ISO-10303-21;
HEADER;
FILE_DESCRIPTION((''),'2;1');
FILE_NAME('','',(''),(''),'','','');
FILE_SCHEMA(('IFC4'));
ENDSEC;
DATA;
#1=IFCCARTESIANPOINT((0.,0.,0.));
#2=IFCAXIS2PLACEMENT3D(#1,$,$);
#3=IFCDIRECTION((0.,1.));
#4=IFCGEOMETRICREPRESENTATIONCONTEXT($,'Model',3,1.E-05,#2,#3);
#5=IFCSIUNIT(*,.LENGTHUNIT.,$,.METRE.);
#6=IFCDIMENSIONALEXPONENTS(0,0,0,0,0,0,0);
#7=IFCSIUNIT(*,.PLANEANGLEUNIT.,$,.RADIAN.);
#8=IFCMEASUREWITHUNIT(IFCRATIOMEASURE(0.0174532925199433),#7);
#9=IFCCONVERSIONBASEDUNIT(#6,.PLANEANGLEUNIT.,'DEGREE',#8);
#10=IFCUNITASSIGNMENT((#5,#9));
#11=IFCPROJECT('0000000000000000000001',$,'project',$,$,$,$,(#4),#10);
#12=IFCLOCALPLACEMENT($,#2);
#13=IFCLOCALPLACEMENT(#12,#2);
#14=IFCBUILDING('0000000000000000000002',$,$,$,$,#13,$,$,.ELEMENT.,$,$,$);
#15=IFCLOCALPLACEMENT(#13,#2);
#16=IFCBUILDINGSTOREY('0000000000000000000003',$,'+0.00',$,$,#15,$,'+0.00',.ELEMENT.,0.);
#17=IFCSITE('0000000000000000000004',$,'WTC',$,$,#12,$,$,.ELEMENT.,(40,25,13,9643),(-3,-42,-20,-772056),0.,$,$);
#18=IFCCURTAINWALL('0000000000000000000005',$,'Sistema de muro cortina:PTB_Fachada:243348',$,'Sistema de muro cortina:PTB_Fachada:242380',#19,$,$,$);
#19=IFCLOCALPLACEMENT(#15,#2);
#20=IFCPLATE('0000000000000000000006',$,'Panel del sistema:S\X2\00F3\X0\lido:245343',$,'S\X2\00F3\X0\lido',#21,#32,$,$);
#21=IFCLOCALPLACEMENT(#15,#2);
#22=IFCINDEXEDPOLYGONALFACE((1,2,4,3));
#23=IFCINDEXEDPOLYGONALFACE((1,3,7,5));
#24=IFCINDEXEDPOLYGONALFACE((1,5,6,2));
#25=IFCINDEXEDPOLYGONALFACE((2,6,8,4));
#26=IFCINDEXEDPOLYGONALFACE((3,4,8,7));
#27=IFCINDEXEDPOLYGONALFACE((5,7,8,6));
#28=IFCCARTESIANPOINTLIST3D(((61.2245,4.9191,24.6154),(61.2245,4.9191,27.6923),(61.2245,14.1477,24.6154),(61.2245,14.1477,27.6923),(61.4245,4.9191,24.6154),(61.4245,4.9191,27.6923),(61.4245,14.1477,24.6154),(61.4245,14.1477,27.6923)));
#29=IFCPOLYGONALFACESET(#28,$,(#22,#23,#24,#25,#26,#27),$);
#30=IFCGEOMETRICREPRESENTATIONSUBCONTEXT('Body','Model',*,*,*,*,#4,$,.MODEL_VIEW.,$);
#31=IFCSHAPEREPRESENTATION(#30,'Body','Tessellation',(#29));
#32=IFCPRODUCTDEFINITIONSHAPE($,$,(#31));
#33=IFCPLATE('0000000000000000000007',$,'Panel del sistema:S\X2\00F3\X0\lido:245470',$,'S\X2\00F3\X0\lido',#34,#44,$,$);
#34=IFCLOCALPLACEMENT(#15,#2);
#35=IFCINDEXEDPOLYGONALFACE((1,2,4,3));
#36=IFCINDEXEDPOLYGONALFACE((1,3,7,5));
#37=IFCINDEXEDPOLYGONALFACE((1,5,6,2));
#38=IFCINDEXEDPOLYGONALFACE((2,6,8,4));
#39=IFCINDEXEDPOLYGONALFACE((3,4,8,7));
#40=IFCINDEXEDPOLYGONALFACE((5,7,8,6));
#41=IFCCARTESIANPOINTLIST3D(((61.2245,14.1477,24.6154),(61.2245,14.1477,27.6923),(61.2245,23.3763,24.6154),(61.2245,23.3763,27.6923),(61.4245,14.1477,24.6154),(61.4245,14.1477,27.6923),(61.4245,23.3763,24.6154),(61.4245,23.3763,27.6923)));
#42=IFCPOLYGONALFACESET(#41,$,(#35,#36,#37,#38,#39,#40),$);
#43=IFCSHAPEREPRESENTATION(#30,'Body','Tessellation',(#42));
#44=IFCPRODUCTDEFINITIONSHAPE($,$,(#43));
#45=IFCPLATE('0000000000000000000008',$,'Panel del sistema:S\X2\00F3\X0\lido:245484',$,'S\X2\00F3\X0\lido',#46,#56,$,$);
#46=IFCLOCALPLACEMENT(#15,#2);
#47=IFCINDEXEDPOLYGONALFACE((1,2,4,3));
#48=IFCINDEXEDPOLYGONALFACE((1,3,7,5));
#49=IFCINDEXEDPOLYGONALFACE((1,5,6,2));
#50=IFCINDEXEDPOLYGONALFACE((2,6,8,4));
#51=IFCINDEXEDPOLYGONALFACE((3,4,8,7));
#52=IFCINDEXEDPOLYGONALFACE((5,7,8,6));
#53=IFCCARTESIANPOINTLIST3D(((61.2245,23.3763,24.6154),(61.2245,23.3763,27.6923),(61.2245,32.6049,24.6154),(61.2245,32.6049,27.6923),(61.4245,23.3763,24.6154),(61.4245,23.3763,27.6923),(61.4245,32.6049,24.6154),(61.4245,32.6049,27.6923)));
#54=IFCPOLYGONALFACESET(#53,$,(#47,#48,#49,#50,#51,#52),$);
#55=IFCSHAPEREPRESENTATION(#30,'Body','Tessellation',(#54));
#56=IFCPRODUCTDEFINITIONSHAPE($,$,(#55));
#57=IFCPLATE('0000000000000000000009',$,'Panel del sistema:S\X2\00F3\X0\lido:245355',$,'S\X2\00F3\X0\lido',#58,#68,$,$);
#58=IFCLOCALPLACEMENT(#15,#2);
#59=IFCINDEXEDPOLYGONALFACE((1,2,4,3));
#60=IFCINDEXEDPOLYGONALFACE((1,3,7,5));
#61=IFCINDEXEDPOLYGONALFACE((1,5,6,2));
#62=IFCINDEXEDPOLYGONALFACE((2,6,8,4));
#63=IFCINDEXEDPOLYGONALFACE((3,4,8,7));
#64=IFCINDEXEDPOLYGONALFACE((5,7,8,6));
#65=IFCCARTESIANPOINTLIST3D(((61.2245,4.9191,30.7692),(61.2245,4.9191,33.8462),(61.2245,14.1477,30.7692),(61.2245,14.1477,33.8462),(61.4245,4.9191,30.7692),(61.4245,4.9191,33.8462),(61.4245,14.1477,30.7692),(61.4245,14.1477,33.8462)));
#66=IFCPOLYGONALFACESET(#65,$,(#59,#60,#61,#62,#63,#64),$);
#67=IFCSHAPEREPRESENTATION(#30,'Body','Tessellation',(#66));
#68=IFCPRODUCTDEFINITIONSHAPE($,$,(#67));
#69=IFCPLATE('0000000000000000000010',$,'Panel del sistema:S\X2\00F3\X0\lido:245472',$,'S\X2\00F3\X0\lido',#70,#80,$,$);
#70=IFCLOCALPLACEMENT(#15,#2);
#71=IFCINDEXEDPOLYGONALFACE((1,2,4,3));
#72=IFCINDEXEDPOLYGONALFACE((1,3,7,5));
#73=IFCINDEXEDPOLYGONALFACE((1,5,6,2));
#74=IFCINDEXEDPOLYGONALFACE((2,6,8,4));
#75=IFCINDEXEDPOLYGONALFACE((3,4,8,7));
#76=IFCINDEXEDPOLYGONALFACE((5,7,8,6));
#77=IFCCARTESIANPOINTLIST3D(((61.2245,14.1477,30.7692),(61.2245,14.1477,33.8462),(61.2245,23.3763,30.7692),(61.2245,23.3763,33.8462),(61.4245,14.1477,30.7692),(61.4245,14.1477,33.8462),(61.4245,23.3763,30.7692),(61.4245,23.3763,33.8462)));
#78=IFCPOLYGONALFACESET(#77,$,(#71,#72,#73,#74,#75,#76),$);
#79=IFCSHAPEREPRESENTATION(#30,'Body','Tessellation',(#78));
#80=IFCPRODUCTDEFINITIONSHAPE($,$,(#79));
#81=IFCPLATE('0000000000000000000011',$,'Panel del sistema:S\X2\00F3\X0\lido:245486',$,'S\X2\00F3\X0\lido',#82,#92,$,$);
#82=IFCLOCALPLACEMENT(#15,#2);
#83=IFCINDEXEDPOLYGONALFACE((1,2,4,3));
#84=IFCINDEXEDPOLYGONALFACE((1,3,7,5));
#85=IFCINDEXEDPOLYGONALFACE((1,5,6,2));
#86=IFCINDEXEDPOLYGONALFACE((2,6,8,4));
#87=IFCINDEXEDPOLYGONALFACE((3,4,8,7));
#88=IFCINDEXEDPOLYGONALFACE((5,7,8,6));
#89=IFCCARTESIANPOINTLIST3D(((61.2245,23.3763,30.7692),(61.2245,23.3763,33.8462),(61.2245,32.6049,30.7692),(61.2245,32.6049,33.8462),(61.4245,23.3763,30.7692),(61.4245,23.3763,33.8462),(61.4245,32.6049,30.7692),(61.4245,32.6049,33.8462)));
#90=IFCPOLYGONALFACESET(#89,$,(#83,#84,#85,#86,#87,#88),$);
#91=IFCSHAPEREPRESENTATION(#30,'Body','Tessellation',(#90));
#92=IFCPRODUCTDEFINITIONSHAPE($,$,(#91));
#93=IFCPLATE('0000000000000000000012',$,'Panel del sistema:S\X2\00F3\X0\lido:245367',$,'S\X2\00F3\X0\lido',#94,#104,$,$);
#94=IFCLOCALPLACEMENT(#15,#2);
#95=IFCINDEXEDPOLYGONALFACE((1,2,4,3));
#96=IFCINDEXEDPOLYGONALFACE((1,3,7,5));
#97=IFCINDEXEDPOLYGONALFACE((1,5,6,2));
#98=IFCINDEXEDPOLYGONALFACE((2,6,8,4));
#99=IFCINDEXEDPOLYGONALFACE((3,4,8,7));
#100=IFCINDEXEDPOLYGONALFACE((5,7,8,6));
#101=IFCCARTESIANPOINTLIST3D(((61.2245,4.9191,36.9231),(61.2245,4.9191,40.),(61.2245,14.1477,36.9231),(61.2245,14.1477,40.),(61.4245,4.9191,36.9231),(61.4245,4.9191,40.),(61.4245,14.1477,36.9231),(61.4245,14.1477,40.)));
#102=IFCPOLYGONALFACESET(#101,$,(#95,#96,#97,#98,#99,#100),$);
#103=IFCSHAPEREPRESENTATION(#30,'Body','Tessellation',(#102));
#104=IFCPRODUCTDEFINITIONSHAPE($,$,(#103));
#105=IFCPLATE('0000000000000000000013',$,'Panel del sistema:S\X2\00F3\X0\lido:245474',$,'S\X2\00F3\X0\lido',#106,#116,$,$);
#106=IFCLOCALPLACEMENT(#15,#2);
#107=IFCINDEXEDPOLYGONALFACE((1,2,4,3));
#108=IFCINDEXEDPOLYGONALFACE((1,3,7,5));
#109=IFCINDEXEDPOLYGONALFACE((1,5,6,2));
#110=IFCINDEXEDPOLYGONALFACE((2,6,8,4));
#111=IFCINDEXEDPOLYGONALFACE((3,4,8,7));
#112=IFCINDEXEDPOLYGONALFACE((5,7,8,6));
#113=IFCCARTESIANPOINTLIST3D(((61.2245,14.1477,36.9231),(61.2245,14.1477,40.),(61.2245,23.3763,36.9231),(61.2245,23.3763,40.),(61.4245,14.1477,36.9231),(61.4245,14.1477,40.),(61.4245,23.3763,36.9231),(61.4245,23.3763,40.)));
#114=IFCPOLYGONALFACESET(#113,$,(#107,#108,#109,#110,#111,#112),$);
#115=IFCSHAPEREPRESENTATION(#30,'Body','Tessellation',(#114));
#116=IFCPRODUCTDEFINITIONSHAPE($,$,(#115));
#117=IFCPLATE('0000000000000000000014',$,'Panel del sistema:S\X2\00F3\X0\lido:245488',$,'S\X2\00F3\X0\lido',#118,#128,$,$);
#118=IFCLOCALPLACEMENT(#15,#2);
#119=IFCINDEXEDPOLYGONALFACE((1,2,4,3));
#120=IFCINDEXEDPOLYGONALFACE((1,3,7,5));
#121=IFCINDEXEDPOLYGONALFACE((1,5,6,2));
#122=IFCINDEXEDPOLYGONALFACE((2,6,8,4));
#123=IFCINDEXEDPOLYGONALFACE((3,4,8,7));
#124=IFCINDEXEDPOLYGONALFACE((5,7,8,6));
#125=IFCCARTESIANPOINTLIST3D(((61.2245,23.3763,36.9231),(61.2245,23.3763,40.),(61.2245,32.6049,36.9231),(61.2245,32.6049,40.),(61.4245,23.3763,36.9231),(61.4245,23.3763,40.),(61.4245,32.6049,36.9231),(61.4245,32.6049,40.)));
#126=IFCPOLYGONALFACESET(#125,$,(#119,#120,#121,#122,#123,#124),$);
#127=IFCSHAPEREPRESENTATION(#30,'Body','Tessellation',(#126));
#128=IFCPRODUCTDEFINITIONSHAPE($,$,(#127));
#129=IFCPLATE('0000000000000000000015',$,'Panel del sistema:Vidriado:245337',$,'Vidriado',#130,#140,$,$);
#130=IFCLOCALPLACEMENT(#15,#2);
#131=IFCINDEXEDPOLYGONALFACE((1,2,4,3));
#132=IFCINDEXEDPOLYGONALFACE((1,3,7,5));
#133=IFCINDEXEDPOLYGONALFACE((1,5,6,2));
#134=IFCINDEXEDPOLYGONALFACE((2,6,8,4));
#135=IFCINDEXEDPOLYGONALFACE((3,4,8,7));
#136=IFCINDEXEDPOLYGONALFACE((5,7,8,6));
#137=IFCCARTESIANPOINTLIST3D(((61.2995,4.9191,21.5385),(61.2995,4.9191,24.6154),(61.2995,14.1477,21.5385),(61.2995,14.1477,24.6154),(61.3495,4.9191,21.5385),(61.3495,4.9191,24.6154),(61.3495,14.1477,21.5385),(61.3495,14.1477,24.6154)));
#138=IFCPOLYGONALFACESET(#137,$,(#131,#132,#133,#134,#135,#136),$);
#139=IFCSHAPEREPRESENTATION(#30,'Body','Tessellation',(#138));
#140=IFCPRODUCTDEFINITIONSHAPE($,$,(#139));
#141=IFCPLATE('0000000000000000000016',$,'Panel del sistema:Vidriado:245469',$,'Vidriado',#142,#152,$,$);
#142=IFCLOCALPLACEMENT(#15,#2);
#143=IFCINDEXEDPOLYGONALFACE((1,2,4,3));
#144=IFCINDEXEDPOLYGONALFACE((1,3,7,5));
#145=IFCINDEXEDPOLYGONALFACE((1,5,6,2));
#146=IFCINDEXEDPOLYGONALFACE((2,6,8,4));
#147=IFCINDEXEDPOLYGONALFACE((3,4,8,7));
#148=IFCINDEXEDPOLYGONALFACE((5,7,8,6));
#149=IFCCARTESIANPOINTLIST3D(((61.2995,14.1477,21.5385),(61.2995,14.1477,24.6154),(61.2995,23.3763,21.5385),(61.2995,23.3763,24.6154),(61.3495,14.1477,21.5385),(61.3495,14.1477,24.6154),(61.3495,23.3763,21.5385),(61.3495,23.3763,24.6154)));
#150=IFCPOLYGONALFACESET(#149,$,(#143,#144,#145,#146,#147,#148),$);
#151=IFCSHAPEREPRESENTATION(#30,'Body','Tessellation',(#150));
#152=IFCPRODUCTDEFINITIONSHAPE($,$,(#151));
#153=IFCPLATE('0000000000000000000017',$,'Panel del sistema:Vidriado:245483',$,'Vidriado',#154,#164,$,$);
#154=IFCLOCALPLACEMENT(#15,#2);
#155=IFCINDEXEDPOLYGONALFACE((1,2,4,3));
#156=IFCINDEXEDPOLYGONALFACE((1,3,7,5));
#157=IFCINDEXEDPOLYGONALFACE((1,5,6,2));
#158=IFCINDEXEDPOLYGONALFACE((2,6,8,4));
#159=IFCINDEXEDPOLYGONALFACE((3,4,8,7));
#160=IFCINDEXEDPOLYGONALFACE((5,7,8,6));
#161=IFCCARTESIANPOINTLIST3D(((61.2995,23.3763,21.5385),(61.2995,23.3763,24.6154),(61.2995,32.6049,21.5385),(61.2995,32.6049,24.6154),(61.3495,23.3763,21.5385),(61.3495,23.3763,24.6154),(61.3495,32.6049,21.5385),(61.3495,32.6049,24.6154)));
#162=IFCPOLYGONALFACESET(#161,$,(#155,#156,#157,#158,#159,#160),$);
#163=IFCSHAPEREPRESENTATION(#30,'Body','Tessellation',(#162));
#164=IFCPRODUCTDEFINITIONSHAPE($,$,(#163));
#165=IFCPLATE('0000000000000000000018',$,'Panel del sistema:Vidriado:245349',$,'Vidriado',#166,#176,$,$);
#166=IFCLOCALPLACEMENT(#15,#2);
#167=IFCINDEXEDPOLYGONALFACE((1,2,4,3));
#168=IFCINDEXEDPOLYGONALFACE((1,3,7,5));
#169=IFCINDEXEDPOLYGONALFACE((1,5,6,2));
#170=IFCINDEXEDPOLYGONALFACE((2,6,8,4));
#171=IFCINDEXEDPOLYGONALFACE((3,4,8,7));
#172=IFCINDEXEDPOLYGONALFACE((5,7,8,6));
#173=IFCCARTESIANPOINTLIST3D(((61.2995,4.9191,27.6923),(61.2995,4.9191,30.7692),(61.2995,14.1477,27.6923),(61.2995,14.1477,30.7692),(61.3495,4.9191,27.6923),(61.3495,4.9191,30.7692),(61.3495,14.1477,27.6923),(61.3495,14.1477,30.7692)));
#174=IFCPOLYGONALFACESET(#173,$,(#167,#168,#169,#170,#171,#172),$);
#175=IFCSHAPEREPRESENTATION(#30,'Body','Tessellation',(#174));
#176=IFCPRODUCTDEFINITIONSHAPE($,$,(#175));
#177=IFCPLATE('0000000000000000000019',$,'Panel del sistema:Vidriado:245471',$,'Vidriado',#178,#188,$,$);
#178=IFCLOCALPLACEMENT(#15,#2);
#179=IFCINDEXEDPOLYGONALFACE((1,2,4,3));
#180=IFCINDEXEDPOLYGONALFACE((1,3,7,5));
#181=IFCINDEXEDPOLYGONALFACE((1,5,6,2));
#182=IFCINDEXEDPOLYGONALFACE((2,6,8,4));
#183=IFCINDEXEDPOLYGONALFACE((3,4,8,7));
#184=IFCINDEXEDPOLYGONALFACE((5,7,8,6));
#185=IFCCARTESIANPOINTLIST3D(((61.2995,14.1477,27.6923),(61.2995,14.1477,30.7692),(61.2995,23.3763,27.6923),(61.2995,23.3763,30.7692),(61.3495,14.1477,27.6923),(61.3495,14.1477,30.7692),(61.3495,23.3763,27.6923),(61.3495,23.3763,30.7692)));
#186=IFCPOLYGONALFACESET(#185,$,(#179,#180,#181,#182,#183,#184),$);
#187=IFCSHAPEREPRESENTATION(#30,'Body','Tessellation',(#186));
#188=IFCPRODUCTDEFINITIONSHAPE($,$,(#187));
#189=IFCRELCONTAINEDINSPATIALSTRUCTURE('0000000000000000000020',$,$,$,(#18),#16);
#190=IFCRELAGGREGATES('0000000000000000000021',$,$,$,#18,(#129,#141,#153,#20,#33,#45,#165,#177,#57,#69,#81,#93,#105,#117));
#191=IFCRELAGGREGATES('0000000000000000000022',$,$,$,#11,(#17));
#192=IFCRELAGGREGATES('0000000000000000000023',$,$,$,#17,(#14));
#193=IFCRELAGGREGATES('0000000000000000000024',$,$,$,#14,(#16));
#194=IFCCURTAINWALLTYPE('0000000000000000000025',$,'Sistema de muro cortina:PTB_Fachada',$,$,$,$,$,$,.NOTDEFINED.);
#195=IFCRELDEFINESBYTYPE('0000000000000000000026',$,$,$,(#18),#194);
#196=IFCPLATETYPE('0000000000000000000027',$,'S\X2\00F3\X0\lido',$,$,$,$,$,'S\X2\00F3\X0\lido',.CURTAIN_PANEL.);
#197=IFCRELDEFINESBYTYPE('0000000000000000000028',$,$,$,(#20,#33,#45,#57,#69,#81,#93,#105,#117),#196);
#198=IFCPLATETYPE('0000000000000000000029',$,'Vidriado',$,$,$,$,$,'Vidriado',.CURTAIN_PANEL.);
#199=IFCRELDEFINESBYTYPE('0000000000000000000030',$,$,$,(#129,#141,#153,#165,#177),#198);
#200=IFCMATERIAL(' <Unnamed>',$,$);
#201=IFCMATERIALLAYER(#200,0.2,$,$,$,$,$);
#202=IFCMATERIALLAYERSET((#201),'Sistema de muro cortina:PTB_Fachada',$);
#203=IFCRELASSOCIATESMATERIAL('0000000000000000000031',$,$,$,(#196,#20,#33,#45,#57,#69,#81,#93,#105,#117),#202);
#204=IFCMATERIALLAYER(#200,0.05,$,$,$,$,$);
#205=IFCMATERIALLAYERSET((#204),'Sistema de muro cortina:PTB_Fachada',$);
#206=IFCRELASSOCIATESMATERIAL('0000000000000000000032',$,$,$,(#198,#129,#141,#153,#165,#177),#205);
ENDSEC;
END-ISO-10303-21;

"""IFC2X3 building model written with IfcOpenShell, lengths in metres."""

from ifc_helpers import new_model, entity, si_unit, converted_unit, direction, frame, frame_2d, origin, origin_2d_with_axis, place, context, subcontext, project, spatial, rectangle, extrude, source, transform, mapped, material, layer, layer_set, layer_usage, type_object, type_shapes, element, aggregate, save


model = new_model("IFC2X3")

# Units and contexts
model_context = context("Model", 3, precision=1e-05, world=origin(), true_north=direction((0.0, 1.0)))
body_context = subcontext(model_context, "Body", "Model", "MODEL_VIEW")
ifc_project = project(units=[si_unit("LENGTHUNIT", "METRE"), converted_unit("PLANEANGLEUNIT", "DEGREE", entity("IfcRatioMeasure", 0.0174532925199433), si_unit("PLANEANGLEUNIT", "RADIAN"), dimensions=[0, 0, 0, 0, 0, 0, 0])], contexts=[model_context])

# Site, building, storey
site_placement = place(None, origin())
site = spatial("IfcSite", under=ifc_project, at=site_placement, Name="WTC", CompositionType="ELEMENT", RefLatitude=(40, 25, 13, 9643), RefLongitude=(-3, -42, -20, -772056), RefElevation=0.0)
building_placement = place(site_placement, origin())
building = spatial("IfcBuilding", under=site, at=building_placement, CompositionType="ELEMENT")
storey_placement = place(building_placement, origin())
storey = spatial("IfcBuildingStorey", under=building, at=storey_placement, Name="+0.00", LongName="+0.00", CompositionType="ELEMENT", Elevation=0.0)

# Curtain wall, plates
curtain_wall_type = type_object("IfcCurtainWallType", Name="Sistema de muro cortina:PTB_Fachada", PredefinedType="NOTDEFINED")
ifc_material_1 = material(Name=" <Unnamed>")
ifc_layer_1 = layer(ifc_material_1, 0.2)
ifc_layer_set_1 = layer_set([ifc_layer_1], Name="Sistema de muro cortina:PTB_Fachada")
ifc_layer_2 = layer(ifc_material_1, 0.05)
ifc_layer_set_2 = layer_set([ifc_layer_2], Name="Sistema de muro cortina:PTB_Fachada")
curtain_wall_1_placement = place(storey_placement, origin())
curtain_wall_1 = element("IfcCurtainWall", 1, at=curtain_wall_1_placement, inside=storey, type_object=curtain_wall_type, Name="Sistema de muro cortina:PTB_Fachada:243348", ObjectType="Sistema de muro cortina:PTB_Fachada:242380")
ifc_layer_usage_1 = layer_usage(ifc_layer_set_1, "AXIS3", "POSITIVE", 0.0)
plate_type_1 = type_object("IfcPlateType", Name="Sólido", ElementType="Sólido", PredefinedType="CURTAIN_PANEL", material=ifc_layer_set_1)
shared_shape_1 = source(origin(), body_context, "Body", "SweptSolid", [
    extrude(rectangle(XDim=0.2, YDim=9.2286, at=frame_2d((0.0, 0.0), x_axis=(1.0, 0.0))), frame((0.0, 0.0, 0.0), z_axis=(0.0, 0.0, 1.0), x_axis=(0.0, 1.0, 0.0)), (0.0, 0.0, 1.0), 3.0769),
])
type_shapes(plate_type_1, [shared_shape_1])
plate_1_placement = place(curtain_wall_1_placement, frame((61.3245, 9.5334, 24.6154), z_axis=(0.0, 0.0, 1.0), x_axis=(0.0, 1.0, 0.0)))
plate_1 = element("IfcPlate", 2, at=plate_1_placement, type_object=plate_type_1, material=ifc_layer_usage_1, Name="Panel del sistema:Sólido:245343", ObjectType="Sólido", context=body_context, shape_type="MappedRepresentation", body=[
    mapped(shared_shape_1, transform((0.0, 0.0, 0.0), scale=1.0)),
])
ifc_layer_usage_2 = layer_usage(ifc_layer_set_1, "AXIS3", "POSITIVE", 0.0)
plate_2_placement = place(curtain_wall_1_placement, frame((61.3245, 18.762, 24.6154), z_axis=(0.0, 0.0, 1.0), x_axis=(0.0, 1.0, 0.0)))
plate_2 = element("IfcPlate", 3, at=plate_2_placement, type_object=plate_type_1, material=ifc_layer_usage_2, Name="Panel del sistema:Sólido:245470", ObjectType="Sólido", context=body_context, shape_type="MappedRepresentation", body=[
    mapped(shared_shape_1, transform((0.0, 0.0, 0.0), scale=1.0)),
])
ifc_layer_usage_3 = layer_usage(ifc_layer_set_1, "AXIS3", "POSITIVE", 0.0)
plate_3_placement = place(curtain_wall_1_placement, frame((61.3245, 27.9906, 24.6154), z_axis=(0.0, 0.0, 1.0), x_axis=(0.0, 1.0, 0.0)))
plate_3 = element("IfcPlate", 4, at=plate_3_placement, type_object=plate_type_1, material=ifc_layer_usage_3, Name="Panel del sistema:Sólido:245484", ObjectType="Sólido", context=body_context, shape_type="MappedRepresentation", body=[
    mapped(shared_shape_1, transform((0.0, 0.0, 0.0), scale=1.0)),
])
ifc_layer_usage_4 = layer_usage(ifc_layer_set_1, "AXIS3", "POSITIVE", 0.0)
plate_4_placement = place(curtain_wall_1_placement, frame((61.3245, 9.5334, 30.7692), z_axis=(0.0, 0.0, 1.0), x_axis=(0.0, 1.0, 0.0)))
plate_4 = element("IfcPlate", 5, at=plate_4_placement, type_object=plate_type_1, material=ifc_layer_usage_4, Name="Panel del sistema:Sólido:245355", ObjectType="Sólido", context=body_context, shape_type="MappedRepresentation", body=[
    mapped(shared_shape_1, transform((0.0, 0.0, 0.0), scale=1.0)),
])
ifc_layer_usage_5 = layer_usage(ifc_layer_set_1, "AXIS3", "POSITIVE", 0.0)
plate_5_placement = place(curtain_wall_1_placement, frame((61.3245, 18.762, 30.7692), z_axis=(0.0, 0.0, 1.0), x_axis=(0.0, 1.0, 0.0)))
plate_5 = element("IfcPlate", 6, at=plate_5_placement, type_object=plate_type_1, material=ifc_layer_usage_5, Name="Panel del sistema:Sólido:245472", ObjectType="Sólido", context=body_context, shape_type="MappedRepresentation", body=[
    mapped(shared_shape_1, transform((0.0, 0.0, 0.0), scale=1.0)),
])
ifc_layer_usage_6 = layer_usage(ifc_layer_set_1, "AXIS3", "POSITIVE", 0.0)
plate_6_placement = place(curtain_wall_1_placement, frame((61.3245, 27.9906, 30.7692), z_axis=(0.0, 0.0, 1.0), x_axis=(0.0, 1.0, 0.0)))
plate_6 = element("IfcPlate", 7, at=plate_6_placement, type_object=plate_type_1, material=ifc_layer_usage_6, Name="Panel del sistema:Sólido:245486", ObjectType="Sólido", context=body_context, shape_type="MappedRepresentation", body=[
    mapped(shared_shape_1, transform((0.0, 0.0, 0.0), scale=1.0)),
])
ifc_layer_usage_7 = layer_usage(ifc_layer_set_1, "AXIS3", "POSITIVE", 0.0)
plate_7_placement = place(curtain_wall_1_placement, frame((61.3245, 9.5334, 36.9231), z_axis=(0.0, 0.0, 1.0), x_axis=(0.0, 1.0, 0.0)))
plate_7 = element("IfcPlate", 8, at=plate_7_placement, type_object=plate_type_1, material=ifc_layer_usage_7, Name="Panel del sistema:Sólido:245367", ObjectType="Sólido", context=body_context, shape_type="MappedRepresentation", body=[
    mapped(shared_shape_1, transform((0.0, 0.0, 0.0), scale=1.0)),
])
ifc_layer_usage_8 = layer_usage(ifc_layer_set_1, "AXIS3", "POSITIVE", 0.0)
plate_8_placement = place(curtain_wall_1_placement, frame((61.3245, 18.762, 36.9231), z_axis=(0.0, 0.0, 1.0), x_axis=(0.0, 1.0, 0.0)))
plate_8 = element("IfcPlate", 9, at=plate_8_placement, type_object=plate_type_1, material=ifc_layer_usage_8, Name="Panel del sistema:Sólido:245474", ObjectType="Sólido", context=body_context, shape_type="MappedRepresentation", body=[
    mapped(shared_shape_1, transform((0.0, 0.0, 0.0), scale=1.0)),
])
ifc_layer_usage_9 = layer_usage(ifc_layer_set_1, "AXIS3", "POSITIVE", 0.0)
plate_9_placement = place(curtain_wall_1_placement, frame((61.3245, 27.9906, 36.9231), z_axis=(0.0, 0.0, 1.0), x_axis=(0.0, 1.0, 0.0)))
plate_9 = element("IfcPlate", 10, at=plate_9_placement, type_object=plate_type_1, material=ifc_layer_usage_9, Name="Panel del sistema:Sólido:245488", ObjectType="Sólido", context=body_context, shape_type="MappedRepresentation", body=[
    mapped(shared_shape_1, transform((0.0, 0.0, 0.0), scale=1.0)),
])
ifc_layer_usage_10 = layer_usage(ifc_layer_set_2, "AXIS3", "POSITIVE", 0.0)
plate_type_2 = type_object("IfcPlateType", Name="Vidriado", ElementType="Vidriado", PredefinedType="CURTAIN_PANEL", material=ifc_layer_set_2)
shared_shape_2 = source(origin(), body_context, "Body", "SweptSolid", [
    extrude(rectangle(XDim=0.05, YDim=9.2286, at=origin_2d_with_axis()), frame((0.0, 0.0, 0.0), z_axis=(0.0, 0.0, 1.0), x_axis=(0.0, 1.0, 0.0)), (0.0, 0.0, 1.0), 3.0769),
])
type_shapes(plate_type_2, [shared_shape_2])
plate_10_placement = place(curtain_wall_1_placement, frame((61.3245, 9.5334, 21.5385), z_axis=(0.0, 0.0, 1.0), x_axis=(0.0, 1.0, 0.0)))
plate_10 = element("IfcPlate", 11, at=plate_10_placement, type_object=plate_type_2, material=ifc_layer_usage_10, Name="Panel del sistema:Vidriado:245337", ObjectType="Vidriado", context=body_context, shape_type="MappedRepresentation", body=[
    mapped(shared_shape_2, transform((0.0, 0.0, 0.0), scale=1.0)),
])
ifc_layer_usage_11 = layer_usage(ifc_layer_set_2, "AXIS3", "POSITIVE", 0.0)
plate_11_placement = place(curtain_wall_1_placement, frame((61.3245, 18.762, 21.5385), z_axis=(0.0, 0.0, 1.0), x_axis=(0.0, 1.0, 0.0)))
plate_11 = element("IfcPlate", 12, at=plate_11_placement, type_object=plate_type_2, material=ifc_layer_usage_11, Name="Panel del sistema:Vidriado:245469", ObjectType="Vidriado", context=body_context, shape_type="MappedRepresentation", body=[
    mapped(shared_shape_2, transform((0.0, 0.0, 0.0), scale=1.0)),
])
ifc_layer_usage_12 = layer_usage(ifc_layer_set_2, "AXIS3", "POSITIVE", 0.0)
plate_12_placement = place(curtain_wall_1_placement, frame((61.3245, 27.9906, 21.5385), z_axis=(0.0, 0.0, 1.0), x_axis=(0.0, 1.0, 0.0)))
plate_12 = element("IfcPlate", 13, at=plate_12_placement, type_object=plate_type_2, material=ifc_layer_usage_12, Name="Panel del sistema:Vidriado:245483", ObjectType="Vidriado", context=body_context, shape_type="MappedRepresentation", body=[
    mapped(shared_shape_2, transform((0.0, 0.0, 0.0), scale=1.0)),
])
ifc_layer_usage_13 = layer_usage(ifc_layer_set_2, "AXIS3", "POSITIVE", 0.0)
plate_13_placement = place(curtain_wall_1_placement, frame((61.3245, 9.5334, 27.6923), z_axis=(0.0, 0.0, 1.0), x_axis=(0.0, 1.0, 0.0)))
plate_13 = element("IfcPlate", 14, at=plate_13_placement, type_object=plate_type_2, material=ifc_layer_usage_13, Name="Panel del sistema:Vidriado:245349", ObjectType="Vidriado", context=body_context, shape_type="MappedRepresentation", body=[
    mapped(shared_shape_2, transform((0.0, 0.0, 0.0), scale=1.0)),
])
ifc_layer_usage_14 = layer_usage(ifc_layer_set_2, "AXIS3", "POSITIVE", 0.0)
plate_14_placement = place(curtain_wall_1_placement, frame((61.3245, 18.762, 27.6923), z_axis=(0.0, 0.0, 1.0), x_axis=(0.0, 1.0, 0.0)))
plate_14 = element("IfcPlate", 15, at=plate_14_placement, type_object=plate_type_2, material=ifc_layer_usage_14, Name="Panel del sistema:Vidriado:245471", ObjectType="Vidriado", context=body_context, shape_type="MappedRepresentation", body=[
    mapped(shared_shape_2, transform((0.0, 0.0, 0.0), scale=1.0)),
])
aggregate(curtain_wall_1, [plate_10, plate_11, plate_12, plate_1, plate_2, plate_3, plate_13, plate_14, plate_4, plate_5, plate_6, plate_7, plate_8, plate_9])

save(model, "model.ifc")
